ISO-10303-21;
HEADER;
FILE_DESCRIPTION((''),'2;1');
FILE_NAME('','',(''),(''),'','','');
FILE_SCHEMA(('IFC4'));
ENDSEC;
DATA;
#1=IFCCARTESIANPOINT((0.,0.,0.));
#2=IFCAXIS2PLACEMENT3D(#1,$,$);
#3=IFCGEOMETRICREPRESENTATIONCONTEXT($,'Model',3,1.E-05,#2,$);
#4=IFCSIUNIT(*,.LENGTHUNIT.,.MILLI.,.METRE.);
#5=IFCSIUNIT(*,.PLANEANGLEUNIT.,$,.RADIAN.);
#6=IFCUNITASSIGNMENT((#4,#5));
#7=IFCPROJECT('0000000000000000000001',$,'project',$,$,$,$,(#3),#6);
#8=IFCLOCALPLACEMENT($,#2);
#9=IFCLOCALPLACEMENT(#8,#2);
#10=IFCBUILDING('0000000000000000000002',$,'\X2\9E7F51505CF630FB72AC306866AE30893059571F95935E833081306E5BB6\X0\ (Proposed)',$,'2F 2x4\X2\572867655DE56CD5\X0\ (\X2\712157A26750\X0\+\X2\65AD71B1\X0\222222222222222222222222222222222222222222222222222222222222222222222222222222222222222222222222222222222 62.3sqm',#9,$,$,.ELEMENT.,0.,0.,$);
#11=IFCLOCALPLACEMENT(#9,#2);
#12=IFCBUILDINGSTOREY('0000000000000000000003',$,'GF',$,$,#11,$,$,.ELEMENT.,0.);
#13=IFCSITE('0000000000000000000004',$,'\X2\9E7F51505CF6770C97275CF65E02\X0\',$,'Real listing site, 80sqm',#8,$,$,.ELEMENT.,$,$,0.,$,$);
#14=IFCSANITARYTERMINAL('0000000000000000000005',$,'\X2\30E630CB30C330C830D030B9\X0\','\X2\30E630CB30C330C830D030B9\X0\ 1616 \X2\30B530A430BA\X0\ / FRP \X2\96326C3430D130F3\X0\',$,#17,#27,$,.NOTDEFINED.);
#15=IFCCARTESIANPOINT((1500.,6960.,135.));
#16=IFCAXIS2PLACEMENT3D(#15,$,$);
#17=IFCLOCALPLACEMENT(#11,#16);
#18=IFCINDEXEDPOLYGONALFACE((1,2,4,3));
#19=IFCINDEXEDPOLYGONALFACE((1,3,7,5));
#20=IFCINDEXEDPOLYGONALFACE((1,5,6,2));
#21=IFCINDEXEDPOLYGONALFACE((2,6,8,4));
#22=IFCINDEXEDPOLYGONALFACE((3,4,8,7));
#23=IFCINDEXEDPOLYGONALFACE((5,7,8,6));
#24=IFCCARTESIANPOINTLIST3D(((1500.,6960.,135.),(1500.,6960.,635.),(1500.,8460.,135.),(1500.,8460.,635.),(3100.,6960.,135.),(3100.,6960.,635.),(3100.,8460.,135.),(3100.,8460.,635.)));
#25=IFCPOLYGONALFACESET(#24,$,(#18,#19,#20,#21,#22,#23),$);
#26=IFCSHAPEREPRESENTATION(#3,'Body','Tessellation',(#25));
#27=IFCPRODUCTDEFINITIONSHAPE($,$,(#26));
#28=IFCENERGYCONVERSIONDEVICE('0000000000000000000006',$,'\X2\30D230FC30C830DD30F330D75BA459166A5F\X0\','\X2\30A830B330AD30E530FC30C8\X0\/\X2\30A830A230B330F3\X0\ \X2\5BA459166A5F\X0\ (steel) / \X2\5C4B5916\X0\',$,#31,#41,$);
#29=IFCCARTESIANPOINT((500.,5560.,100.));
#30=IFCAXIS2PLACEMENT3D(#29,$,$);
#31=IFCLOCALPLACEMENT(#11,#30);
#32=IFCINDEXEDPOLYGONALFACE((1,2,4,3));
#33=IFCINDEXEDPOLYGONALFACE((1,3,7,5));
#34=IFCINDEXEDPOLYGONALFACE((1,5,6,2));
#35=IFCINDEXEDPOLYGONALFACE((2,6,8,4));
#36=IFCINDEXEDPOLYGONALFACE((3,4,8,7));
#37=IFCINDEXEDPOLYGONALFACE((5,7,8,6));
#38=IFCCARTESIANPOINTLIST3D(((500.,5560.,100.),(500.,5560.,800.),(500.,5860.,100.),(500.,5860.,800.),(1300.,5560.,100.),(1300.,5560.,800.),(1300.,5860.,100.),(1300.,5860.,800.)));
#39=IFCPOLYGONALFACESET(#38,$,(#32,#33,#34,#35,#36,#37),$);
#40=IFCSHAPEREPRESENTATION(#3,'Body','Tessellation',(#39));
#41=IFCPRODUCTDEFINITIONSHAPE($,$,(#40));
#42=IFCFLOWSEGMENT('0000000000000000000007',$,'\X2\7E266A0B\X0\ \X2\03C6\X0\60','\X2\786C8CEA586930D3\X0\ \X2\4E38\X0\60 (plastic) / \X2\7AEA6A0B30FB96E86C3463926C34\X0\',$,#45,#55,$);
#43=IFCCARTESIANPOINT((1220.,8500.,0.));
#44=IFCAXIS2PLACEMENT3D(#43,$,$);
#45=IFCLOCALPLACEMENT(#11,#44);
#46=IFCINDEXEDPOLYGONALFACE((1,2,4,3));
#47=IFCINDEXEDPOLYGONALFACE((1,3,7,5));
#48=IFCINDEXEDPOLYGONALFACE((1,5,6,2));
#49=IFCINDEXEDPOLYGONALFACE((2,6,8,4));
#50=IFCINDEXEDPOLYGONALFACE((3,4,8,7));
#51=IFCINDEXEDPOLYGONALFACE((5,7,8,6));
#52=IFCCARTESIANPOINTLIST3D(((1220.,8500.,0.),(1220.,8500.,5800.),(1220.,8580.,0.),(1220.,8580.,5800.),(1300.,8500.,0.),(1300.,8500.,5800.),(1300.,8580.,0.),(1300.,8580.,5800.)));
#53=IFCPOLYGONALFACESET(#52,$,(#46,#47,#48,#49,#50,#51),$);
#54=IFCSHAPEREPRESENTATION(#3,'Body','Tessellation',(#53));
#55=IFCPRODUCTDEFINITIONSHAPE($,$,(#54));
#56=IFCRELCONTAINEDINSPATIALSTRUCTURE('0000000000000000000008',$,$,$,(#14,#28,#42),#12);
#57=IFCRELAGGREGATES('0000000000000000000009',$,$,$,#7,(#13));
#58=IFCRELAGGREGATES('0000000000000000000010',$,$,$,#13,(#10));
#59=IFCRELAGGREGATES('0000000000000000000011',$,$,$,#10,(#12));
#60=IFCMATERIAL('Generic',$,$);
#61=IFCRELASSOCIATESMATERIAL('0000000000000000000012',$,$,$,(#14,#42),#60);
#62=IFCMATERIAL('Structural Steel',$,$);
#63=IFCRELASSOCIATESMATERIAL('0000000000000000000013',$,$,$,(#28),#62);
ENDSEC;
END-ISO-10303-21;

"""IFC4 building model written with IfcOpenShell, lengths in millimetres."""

from ifc_helpers import new_model, si_unit, frame, frame_2d, origin, place, context, project, spatial, rectangle, extrude, material, element, save


model = new_model("IFC4")

# Units and contexts
model_context = context("Model", 3, precision=1e-05, world=origin())
ifc_project = project(units=[si_unit("LENGTHUNIT", "METRE", prefix="MILLI"), si_unit("PLANEANGLEUNIT", "RADIAN")], contexts=[model_context])

# Site, building, storey
site_placement = place(None, origin())
site = spatial("IfcSite", under=ifc_project, at=site_placement, Name="鹿児島県霧島市", ObjectType="Real listing site, 80sqm", CompositionType="ELEMENT", RefElevation=0.0)
building_placement = place(site_placement, origin())
building = spatial("IfcBuilding", under=site, at=building_placement, Name="鹿児島・犬と暮らす土間広めの家 (Proposed)", ObjectType="2F 2x4在来工法 (無垢材+断熱222222222222222222222222222222222222222222222222222222222222222222222222222222222222222222222222222222222 62.3sqm", CompositionType="ELEMENT", ElevationOfRefHeight=0.0, ElevationOfTerrain=0.0)
storey_placement = place(building_placement, origin())
storey = spatial("IfcBuildingStorey", under=building, at=storey_placement, Name="GF", CompositionType="ELEMENT", Elevation=0.0)

# Shared definitions
ifc_material_1 = material(Name="Generic")

# Sanitary terminal
sanitary_terminal_placement = place(storey_placement, frame((1500.0, 6960.0, 135.0)))
element("IfcSanitaryTerminal", 1, at=sanitary_terminal_placement, inside=storey, material=ifc_material_1, Name="ユニットバス", Description="ユニットバス 1616 サイズ / FRP 防水パン", PredefinedType="NOTDEFINED", context=model_context, shape_type="SweptSolid", body=[
    extrude(rectangle(XDim=1600.0, YDim=1500.0, at=frame_2d((800.0, 750.0))), frame((1500.0, 6960.0, 135.0)), (0.0, 0.0, 1.0), 500.0),
])

# Energy conversion device
ifc_material_2 = material(Name="Structural Steel")
energy_conversion_device_placement = place(storey_placement, frame((500.0, 5560.0, 100.0)))
element("IfcEnergyConversionDevice", 2, at=energy_conversion_device_placement, inside=storey, material=ifc_material_2, Name="ヒートポンプ室外機", Description="エコキュート/エアコン 室外機 (steel) / 屋外", context=model_context, shape_type="SweptSolid", body=[
    extrude(rectangle(XDim=800.0, YDim=300.0, at=frame_2d((400.0, 150.0))), frame((500.0, 5560.0, 100.0)), (0.0, 0.0, 1.0), 700.0),
])

# Flow segment
flow_segment_placement = place(storey_placement, frame((1220.0, 8500.0, 0.0)))
element("IfcFlowSegment", 3, at=flow_segment_placement, inside=storey, material=ifc_material_1, Name="縦樋 φ60", Description="硬質塩ビ 丸60 (plastic) / 竪樋・雨水排水", context=model_context, shape_type="SweptSolid", body=[
    extrude(rectangle(XDim=80.0, YDim=80.0, at=frame_2d((40.0, 40.0))), frame((1220.0, 8500.0, 0.0)), (0.0, 0.0, 1.0), 5800.0),
])

save(model, "model.ifc")
